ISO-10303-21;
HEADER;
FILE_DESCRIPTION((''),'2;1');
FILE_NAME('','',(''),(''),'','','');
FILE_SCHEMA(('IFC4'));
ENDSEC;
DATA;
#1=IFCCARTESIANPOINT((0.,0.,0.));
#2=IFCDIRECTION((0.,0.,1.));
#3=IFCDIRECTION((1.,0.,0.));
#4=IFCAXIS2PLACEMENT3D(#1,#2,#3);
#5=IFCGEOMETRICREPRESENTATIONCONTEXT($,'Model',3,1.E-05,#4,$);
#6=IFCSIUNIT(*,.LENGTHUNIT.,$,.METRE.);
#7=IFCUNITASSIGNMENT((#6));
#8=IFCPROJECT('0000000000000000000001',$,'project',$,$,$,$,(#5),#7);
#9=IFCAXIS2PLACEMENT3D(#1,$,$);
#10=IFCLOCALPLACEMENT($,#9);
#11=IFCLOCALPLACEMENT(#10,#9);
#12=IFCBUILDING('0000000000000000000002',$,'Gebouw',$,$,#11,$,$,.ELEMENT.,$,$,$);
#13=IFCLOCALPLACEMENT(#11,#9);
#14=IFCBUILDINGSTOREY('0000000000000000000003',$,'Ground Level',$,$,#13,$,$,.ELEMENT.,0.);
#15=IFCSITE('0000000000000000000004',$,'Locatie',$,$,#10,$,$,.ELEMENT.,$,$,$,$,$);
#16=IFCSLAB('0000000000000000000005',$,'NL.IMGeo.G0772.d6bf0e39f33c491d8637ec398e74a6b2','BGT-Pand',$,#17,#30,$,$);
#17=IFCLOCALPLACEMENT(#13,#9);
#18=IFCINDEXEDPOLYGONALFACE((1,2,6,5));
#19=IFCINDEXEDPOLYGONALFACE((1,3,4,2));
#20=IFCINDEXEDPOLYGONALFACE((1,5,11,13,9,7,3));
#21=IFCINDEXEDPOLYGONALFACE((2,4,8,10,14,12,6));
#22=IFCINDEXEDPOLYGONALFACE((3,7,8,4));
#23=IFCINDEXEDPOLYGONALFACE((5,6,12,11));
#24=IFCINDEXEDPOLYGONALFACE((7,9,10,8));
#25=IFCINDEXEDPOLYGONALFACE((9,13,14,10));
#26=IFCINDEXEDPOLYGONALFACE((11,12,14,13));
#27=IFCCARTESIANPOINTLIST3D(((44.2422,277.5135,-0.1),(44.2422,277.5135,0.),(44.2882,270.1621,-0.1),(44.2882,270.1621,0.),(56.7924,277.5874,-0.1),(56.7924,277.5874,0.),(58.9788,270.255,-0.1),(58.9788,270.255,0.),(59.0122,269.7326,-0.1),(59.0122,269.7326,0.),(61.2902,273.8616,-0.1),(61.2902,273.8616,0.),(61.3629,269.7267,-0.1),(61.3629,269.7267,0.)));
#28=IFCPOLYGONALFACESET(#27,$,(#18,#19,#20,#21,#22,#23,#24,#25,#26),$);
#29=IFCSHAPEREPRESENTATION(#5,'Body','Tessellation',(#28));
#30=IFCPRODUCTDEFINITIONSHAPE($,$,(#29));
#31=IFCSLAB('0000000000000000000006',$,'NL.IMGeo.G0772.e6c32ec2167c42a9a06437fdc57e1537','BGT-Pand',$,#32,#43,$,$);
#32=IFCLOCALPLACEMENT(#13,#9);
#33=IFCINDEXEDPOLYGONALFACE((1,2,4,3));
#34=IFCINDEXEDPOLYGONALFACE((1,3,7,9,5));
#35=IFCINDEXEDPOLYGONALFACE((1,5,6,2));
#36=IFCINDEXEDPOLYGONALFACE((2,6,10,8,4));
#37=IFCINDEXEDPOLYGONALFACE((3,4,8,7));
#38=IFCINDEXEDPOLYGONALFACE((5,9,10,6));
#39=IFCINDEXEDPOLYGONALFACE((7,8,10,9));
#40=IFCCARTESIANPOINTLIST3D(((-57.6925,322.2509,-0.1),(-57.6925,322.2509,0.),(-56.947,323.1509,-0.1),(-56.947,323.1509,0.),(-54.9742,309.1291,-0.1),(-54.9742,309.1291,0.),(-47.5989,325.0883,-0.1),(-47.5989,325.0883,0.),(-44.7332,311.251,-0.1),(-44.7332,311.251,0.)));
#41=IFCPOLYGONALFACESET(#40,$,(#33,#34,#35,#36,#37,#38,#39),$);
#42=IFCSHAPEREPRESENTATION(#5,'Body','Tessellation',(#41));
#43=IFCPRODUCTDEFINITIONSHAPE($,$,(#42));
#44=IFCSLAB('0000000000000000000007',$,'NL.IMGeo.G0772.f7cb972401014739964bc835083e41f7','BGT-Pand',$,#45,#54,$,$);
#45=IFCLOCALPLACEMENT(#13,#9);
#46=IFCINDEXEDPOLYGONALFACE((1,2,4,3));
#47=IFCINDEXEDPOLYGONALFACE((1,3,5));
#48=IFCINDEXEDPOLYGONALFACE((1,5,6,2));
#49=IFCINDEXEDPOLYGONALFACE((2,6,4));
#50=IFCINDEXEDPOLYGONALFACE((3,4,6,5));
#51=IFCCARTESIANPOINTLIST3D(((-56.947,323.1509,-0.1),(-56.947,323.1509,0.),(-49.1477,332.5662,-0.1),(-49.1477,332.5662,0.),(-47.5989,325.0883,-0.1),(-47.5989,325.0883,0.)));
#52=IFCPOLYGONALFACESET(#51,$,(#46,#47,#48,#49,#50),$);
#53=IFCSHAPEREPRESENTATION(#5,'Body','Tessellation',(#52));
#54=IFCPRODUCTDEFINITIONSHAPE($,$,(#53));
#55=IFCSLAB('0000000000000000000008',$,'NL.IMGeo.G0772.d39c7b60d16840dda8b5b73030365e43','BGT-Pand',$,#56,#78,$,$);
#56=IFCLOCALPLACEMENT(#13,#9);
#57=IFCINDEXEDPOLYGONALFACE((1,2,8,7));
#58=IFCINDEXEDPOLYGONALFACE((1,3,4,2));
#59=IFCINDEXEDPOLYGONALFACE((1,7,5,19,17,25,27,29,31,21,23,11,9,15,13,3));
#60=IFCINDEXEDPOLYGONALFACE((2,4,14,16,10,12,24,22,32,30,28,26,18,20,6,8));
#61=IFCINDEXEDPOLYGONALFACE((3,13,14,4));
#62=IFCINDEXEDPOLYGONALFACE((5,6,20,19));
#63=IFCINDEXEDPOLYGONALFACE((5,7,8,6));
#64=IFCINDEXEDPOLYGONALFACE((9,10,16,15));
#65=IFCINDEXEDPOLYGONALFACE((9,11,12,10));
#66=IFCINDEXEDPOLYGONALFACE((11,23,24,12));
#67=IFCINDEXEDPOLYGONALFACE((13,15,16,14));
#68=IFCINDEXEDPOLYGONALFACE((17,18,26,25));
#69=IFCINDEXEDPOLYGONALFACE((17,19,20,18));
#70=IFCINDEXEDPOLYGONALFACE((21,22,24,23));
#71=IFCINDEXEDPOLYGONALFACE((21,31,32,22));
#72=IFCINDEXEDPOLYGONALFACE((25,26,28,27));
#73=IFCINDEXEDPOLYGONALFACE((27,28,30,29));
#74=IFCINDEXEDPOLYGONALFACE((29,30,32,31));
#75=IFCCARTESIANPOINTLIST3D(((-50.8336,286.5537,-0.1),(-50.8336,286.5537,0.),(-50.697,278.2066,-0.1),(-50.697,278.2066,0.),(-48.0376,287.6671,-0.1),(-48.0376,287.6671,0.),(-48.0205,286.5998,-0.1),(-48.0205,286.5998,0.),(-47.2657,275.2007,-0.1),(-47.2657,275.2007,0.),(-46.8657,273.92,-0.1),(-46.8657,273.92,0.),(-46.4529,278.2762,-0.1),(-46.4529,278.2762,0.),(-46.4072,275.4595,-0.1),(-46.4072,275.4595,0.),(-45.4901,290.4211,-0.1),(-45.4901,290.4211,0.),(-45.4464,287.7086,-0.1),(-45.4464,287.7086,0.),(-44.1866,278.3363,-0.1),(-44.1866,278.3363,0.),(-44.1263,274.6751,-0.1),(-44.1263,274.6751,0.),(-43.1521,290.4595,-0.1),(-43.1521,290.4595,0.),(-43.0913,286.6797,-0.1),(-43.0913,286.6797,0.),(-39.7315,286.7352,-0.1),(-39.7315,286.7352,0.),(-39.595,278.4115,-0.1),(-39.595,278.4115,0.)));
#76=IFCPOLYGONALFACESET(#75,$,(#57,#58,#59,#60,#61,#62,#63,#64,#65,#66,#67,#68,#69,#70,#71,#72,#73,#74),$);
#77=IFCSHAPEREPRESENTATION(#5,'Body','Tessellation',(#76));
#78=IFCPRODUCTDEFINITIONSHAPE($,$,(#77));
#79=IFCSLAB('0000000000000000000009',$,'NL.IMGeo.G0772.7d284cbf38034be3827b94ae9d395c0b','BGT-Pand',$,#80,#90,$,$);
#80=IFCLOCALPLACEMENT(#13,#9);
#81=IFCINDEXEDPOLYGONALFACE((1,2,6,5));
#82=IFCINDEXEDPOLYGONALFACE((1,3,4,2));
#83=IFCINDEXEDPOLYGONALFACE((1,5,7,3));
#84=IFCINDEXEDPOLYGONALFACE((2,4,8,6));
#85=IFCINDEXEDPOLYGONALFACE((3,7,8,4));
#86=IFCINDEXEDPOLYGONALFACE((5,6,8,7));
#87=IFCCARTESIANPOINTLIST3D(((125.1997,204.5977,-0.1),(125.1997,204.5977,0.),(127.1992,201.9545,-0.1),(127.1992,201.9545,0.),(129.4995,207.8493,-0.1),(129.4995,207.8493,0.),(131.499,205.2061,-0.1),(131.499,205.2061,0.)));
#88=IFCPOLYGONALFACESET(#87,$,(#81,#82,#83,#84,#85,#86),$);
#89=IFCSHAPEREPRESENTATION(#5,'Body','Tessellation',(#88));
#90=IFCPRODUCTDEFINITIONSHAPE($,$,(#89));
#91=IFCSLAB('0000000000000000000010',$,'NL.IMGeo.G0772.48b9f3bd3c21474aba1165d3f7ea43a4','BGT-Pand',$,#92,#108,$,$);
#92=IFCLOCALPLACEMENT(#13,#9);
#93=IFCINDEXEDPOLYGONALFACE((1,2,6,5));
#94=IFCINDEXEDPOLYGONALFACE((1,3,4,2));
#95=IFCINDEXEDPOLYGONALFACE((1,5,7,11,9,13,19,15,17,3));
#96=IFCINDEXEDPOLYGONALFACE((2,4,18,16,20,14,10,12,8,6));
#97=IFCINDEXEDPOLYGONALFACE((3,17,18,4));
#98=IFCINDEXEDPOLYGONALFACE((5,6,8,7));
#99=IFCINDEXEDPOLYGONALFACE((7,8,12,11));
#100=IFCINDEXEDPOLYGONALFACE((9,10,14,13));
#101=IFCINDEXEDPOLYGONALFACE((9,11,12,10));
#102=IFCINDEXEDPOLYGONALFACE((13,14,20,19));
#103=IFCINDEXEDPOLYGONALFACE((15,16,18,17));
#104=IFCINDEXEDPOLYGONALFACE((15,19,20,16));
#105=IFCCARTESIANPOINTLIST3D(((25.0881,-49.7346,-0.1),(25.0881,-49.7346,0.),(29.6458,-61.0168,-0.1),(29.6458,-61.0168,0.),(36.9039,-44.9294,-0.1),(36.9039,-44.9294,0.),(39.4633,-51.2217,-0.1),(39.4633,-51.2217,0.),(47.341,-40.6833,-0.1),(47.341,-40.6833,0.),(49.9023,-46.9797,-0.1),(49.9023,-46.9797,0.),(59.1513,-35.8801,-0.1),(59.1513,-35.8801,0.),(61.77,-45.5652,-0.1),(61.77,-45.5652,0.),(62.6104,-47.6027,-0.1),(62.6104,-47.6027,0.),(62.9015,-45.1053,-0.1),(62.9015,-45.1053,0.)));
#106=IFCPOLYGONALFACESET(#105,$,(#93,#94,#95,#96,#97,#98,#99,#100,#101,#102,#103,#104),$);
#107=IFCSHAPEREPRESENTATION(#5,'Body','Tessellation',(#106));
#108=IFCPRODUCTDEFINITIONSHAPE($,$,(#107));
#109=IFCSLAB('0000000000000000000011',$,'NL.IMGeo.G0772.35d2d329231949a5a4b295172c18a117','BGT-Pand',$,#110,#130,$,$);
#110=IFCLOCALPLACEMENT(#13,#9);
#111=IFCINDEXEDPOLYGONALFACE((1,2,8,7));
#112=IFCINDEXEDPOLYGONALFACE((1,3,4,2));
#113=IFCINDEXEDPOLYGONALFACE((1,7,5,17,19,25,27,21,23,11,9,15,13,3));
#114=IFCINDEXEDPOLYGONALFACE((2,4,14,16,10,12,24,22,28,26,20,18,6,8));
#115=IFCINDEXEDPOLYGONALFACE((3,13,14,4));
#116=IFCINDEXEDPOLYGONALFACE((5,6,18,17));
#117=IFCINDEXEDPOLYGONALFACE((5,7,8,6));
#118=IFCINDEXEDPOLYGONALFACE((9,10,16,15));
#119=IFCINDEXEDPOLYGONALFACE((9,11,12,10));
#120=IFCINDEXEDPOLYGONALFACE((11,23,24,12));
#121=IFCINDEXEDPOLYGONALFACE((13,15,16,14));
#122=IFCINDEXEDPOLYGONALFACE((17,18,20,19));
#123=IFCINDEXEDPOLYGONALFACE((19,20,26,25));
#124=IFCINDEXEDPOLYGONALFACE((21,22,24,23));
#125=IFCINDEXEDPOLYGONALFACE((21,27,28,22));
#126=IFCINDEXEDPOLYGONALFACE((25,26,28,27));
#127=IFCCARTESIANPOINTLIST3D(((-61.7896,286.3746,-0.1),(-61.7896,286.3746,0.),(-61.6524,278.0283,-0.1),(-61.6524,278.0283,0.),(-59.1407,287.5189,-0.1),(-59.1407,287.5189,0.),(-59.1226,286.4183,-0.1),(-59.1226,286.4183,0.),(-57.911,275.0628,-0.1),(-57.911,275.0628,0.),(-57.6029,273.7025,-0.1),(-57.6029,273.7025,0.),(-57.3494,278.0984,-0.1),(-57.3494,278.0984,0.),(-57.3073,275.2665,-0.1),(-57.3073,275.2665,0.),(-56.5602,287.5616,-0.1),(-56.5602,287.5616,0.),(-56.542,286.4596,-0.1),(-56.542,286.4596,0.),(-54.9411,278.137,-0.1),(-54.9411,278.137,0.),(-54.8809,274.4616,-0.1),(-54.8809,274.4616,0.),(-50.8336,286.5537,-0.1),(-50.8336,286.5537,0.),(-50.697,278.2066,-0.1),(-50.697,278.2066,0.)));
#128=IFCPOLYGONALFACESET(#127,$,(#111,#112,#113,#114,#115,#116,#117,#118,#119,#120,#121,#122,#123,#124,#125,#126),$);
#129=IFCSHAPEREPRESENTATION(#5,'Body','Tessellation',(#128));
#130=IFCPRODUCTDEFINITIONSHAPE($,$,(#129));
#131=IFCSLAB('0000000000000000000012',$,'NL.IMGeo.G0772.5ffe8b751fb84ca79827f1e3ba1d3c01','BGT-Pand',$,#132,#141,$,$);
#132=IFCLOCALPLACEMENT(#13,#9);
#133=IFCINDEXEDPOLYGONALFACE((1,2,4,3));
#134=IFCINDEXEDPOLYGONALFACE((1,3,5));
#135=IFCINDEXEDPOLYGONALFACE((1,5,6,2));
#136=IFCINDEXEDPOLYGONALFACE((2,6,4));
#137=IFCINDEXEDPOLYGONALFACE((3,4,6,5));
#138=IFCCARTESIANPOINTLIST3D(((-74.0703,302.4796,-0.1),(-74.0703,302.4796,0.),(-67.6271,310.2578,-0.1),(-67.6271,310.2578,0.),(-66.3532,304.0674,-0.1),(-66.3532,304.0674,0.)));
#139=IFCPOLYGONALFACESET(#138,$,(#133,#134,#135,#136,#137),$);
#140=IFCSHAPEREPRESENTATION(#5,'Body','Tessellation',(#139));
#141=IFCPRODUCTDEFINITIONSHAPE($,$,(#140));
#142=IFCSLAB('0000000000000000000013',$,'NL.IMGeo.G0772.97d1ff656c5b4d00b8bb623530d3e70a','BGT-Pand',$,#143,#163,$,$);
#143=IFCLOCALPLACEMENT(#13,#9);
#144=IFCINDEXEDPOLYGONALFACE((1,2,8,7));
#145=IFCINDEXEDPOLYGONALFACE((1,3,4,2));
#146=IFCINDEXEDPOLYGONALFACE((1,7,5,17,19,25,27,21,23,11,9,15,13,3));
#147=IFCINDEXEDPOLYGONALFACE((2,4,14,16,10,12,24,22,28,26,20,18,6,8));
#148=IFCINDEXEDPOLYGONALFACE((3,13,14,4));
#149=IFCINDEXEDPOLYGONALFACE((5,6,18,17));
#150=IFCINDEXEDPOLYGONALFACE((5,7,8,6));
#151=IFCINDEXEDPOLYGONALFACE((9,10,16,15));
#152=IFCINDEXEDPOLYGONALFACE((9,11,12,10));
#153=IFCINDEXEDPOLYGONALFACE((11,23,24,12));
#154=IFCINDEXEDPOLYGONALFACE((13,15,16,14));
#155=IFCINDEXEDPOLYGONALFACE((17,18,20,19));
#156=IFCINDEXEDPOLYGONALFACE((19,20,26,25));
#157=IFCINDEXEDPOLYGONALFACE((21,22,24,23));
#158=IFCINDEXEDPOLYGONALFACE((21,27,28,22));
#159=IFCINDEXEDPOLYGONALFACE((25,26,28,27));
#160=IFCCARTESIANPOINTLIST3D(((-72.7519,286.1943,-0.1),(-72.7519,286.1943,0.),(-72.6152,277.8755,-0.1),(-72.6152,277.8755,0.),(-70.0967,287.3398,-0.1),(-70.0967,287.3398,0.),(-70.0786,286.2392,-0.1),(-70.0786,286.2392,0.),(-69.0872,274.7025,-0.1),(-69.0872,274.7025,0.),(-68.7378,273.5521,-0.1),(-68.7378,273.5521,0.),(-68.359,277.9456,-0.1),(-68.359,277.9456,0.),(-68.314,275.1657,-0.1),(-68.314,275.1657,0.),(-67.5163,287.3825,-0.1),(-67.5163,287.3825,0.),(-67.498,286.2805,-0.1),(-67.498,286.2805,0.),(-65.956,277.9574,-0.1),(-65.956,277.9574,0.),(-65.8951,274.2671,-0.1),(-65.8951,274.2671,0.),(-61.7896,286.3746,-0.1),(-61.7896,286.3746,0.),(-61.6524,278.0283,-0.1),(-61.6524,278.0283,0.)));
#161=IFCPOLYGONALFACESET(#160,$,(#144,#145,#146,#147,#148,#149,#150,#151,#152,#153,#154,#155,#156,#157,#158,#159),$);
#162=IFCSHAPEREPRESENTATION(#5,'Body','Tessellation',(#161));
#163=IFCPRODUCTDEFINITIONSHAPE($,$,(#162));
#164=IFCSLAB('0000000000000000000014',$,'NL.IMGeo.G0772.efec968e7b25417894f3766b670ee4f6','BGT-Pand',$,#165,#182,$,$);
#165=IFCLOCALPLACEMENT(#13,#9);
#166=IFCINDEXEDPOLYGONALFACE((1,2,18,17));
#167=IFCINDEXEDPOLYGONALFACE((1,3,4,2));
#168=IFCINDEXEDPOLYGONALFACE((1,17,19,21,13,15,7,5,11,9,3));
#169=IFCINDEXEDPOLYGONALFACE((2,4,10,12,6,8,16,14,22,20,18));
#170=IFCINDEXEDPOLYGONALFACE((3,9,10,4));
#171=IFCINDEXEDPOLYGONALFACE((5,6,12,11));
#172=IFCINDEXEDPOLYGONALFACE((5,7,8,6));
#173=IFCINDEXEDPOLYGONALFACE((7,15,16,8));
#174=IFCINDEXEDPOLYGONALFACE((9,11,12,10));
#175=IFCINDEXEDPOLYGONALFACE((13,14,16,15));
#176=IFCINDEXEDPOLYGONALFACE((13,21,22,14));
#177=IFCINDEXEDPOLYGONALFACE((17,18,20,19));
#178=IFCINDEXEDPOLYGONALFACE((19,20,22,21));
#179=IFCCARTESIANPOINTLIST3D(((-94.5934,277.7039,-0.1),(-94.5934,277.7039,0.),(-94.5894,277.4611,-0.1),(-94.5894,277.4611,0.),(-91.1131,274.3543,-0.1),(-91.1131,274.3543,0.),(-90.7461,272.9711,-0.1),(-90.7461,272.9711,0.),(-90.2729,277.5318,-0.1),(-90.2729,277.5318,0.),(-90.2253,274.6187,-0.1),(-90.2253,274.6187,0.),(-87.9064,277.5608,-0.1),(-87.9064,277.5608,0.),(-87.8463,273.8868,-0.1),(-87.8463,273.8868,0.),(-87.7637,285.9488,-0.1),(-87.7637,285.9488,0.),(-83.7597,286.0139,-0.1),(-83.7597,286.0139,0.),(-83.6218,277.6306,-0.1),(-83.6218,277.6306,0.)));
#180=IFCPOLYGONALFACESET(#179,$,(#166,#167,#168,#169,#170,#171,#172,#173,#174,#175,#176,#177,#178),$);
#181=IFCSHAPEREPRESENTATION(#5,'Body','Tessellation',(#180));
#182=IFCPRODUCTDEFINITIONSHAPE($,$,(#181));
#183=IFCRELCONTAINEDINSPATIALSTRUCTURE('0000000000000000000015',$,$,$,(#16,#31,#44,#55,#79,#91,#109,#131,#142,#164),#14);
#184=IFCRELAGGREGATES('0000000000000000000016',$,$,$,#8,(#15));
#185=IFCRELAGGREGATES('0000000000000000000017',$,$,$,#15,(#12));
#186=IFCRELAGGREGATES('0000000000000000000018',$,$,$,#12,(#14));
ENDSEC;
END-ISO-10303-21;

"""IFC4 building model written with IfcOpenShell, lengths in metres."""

from ifc_helpers import new_model, si_unit, frame, origin, origin_with_axes, place, context, project, spatial, polyline, outline, extrude, element, save


model = new_model("IFC4")

# Units and contexts
model_context = context("Model", 3, precision=1e-05, world=origin_with_axes())
ifc_project = project(units=[si_unit("LENGTHUNIT", "METRE")], contexts=[model_context])

# Site, building, storey
site_placement = place(None, origin())
site = spatial("IfcSite", under=ifc_project, at=site_placement, Name="Locatie", CompositionType="ELEMENT")
building_placement = place(site_placement, origin())
building = spatial("IfcBuilding", under=site, at=building_placement, Name="Gebouw", CompositionType="ELEMENT")
storey_placement = place(building_placement, origin())
storey = spatial("IfcBuildingStorey", under=building, at=storey_placement, Name="Ground Level", CompositionType="ELEMENT", Elevation=0.0)

# Slabs
slab_1_placement = place(storey_placement, origin())
element("IfcSlab", 1, at=slab_1_placement, inside=storey, Name="NL.IMGeo.G0772.d6bf0e39f33c491d8637ec398e74a6b2", Description="BGT-Pand", context=model_context, shape_type="SweptSolid", body=[
    extrude(outline(polyline([(61.3629, 269.7267), (59.0122, 269.7326), (58.9788, 270.255), (44.2882, 270.1621), (44.2422, 277.5135), (56.7924, 277.5874), (61.2902, 273.8616), (61.3629, 269.7267)])), frame((0.0, 0.0, -0.1), z_axis=(0.0, 0.0, 1.0), x_axis=(1.0, 0.0, 0.0)), (0.0, 0.0, 1.0), 0.1),
])
slab_2_placement = place(storey_placement, origin())
element("IfcSlab", 2, at=slab_2_placement, inside=storey, Name="NL.IMGeo.G0772.e6c32ec2167c42a9a06437fdc57e1537", Description="BGT-Pand", context=model_context, shape_type="SweptSolid", body=[
    extrude(outline(polyline([(-47.5989, 325.0883), (-44.7332, 311.251), (-54.9742, 309.1291), (-57.6925, 322.2509), (-56.947, 323.1509), (-47.5989, 325.0883)])), frame((0.0, 0.0, -0.1), z_axis=(0.0, 0.0, 1.0), x_axis=(1.0, 0.0, 0.0)), (0.0, 0.0, 1.0), 0.1),
])
slab_3_placement = place(storey_placement, origin())
element("IfcSlab", 3, at=slab_3_placement, inside=storey, Name="NL.IMGeo.G0772.f7cb972401014739964bc835083e41f7", Description="BGT-Pand", context=model_context, shape_type="SweptSolid", body=[
    extrude(outline(polyline([(-47.5989, 325.0883), (-56.947, 323.1509), (-49.1477, 332.5662), (-47.5989, 325.0883)])), frame((0.0, 0.0, -0.1), z_axis=(0.0, 0.0, 1.0), x_axis=(1.0, 0.0, 0.0)), (0.0, 0.0, 1.0), 0.1),
])
slab_4_placement = place(storey_placement, origin())
element("IfcSlab", 4, at=slab_4_placement, inside=storey, Name="NL.IMGeo.G0772.d39c7b60d16840dda8b5b73030365e43", Description="BGT-Pand", context=model_context, shape_type="SweptSolid", body=[
    extrude(outline(polyline([(-39.7315, 286.7352), (-39.595, 278.4115), (-44.1866, 278.3363), (-44.1263, 274.6751), (-46.8657, 273.92), (-47.2657, 275.2007), (-46.4072, 275.4595), (-46.4529, 278.2762), (-50.697, 278.2066), (-50.8336, 286.5537), (-48.0205, 286.5998), (-48.0376, 287.6671), (-45.4464, 287.7086), (-45.4901, 290.4211), (-43.1521, 290.4595), (-43.0913, 286.6797), (-39.7315, 286.7352)])), frame((0.0, 0.0, -0.1), z_axis=(0.0, 0.0, 1.0), x_axis=(1.0, 0.0, 0.0)), (0.0, 0.0, 1.0), 0.1),
])
slab_5_placement = place(storey_placement, origin())
element("IfcSlab", 5, at=slab_5_placement, inside=storey, Name="NL.IMGeo.G0772.7d284cbf38034be3827b94ae9d395c0b", Description="BGT-Pand", context=model_context, shape_type="SweptSolid", body=[
    extrude(outline(polyline([(125.1997, 204.5977), (129.4995, 207.8493), (131.499, 205.2061), (127.1992, 201.9545), (125.1997, 204.5977)])), frame((0.0, 0.0, -0.1), z_axis=(0.0, 0.0, 1.0), x_axis=(1.0, 0.0, 0.0)), (0.0, 0.0, 1.0), 0.1),
])
slab_6_placement = place(storey_placement, origin())
element("IfcSlab", 6, at=slab_6_placement, inside=storey, Name="NL.IMGeo.G0772.48b9f3bd3c21474aba1165d3f7ea43a4", Description="BGT-Pand", context=model_context, shape_type="SweptSolid", body=[
    extrude(outline(polyline([(39.4633, -51.2217), (49.9023, -46.9797), (47.341, -40.6833), (59.1513, -35.8801), (62.9015, -45.1053), (61.77, -45.5652), (62.6104, -47.6027), (29.6458, -61.0168), (25.0881, -49.7346), (36.9039, -44.9294), (39.4633, -51.2217)])), frame((0.0, 0.0, -0.1), z_axis=(0.0, 0.0, 1.0), x_axis=(1.0, 0.0, 0.0)), (0.0, 0.0, 1.0), 0.1),
])
slab_7_placement = place(storey_placement, origin())
element("IfcSlab", 7, at=slab_7_placement, inside=storey, Name="NL.IMGeo.G0772.35d2d329231949a5a4b295172c18a117", Description="BGT-Pand", context=model_context, shape_type="SweptSolid", body=[
    extrude(outline(polyline([(-50.8336, 286.5537), (-50.697, 278.2066), (-54.9411, 278.137), (-54.8809, 274.4616), (-57.6029, 273.7025), (-57.911, 275.0628), (-57.3073, 275.2665), (-57.3494, 278.0984), (-61.6524, 278.0283), (-61.7896, 286.3746), (-59.1226, 286.4183), (-59.1407, 287.5189), (-56.5602, 287.5616), (-56.542, 286.4596), (-50.8336, 286.5537)])), frame((0.0, 0.0, -0.1), z_axis=(0.0, 0.0, 1.0), x_axis=(1.0, 0.0, 0.0)), (0.0, 0.0, 1.0), 0.1),
])
slab_8_placement = place(storey_placement, origin())
element("IfcSlab", 8, at=slab_8_placement, inside=storey, Name="NL.IMGeo.G0772.5ffe8b751fb84ca79827f1e3ba1d3c01", Description="BGT-Pand", context=model_context, shape_type="SweptSolid", body=[
    extrude(outline(polyline([(-66.3532, 304.0674), (-74.0703, 302.4796), (-67.6271, 310.2578), (-66.3532, 304.0674)])), frame((0.0, 0.0, -0.1), z_axis=(0.0, 0.0, 1.0), x_axis=(1.0, 0.0, 0.0)), (0.0, 0.0, 1.0), 0.1),
])
slab_9_placement = place(storey_placement, origin())
element("IfcSlab", 9, at=slab_9_placement, inside=storey, Name="NL.IMGeo.G0772.97d1ff656c5b4d00b8bb623530d3e70a", Description="BGT-Pand", context=model_context, shape_type="SweptSolid", body=[
    extrude(outline(polyline([(-61.7896, 286.3746), (-61.6524, 278.0283), (-65.956, 277.9574), (-65.8951, 274.2671), (-68.7378, 273.5521), (-69.0872, 274.7025), (-68.314, 275.1657), (-68.359, 277.9456), (-72.6152, 277.8755), (-72.7519, 286.1943), (-70.0786, 286.2392), (-70.0967, 287.3398), (-67.5163, 287.3825), (-67.498, 286.2805), (-61.7896, 286.3746)])), frame((0.0, 0.0, -0.1), z_axis=(0.0, 0.0, 1.0), x_axis=(1.0, 0.0, 0.0)), (0.0, 0.0, 1.0), 0.1),
])
slab_10_placement = place(storey_placement, origin())
element("IfcSlab", 10, at=slab_10_placement, inside=storey, Name="NL.IMGeo.G0772.efec968e7b25417894f3766b670ee4f6", Description="BGT-Pand", context=model_context, shape_type="SweptSolid", body=[
    extrude(outline(polyline([(-83.7597, 286.0139), (-83.6218, 277.6306), (-87.9064, 277.5608), (-87.8463, 273.8868), (-90.7461, 272.9711), (-91.1131, 274.3543), (-90.2253, 274.6187), (-90.2729, 277.5318), (-94.5894, 277.4611), (-94.5934, 277.7039), (-87.7637, 285.9488), (-83.7597, 286.0139)])), frame((0.0, 0.0, -0.1), z_axis=(0.0, 0.0, 1.0), x_axis=(1.0, 0.0, 0.0)), (0.0, 0.0, 1.0), 0.1),
])

save(model, "model.ifc")
